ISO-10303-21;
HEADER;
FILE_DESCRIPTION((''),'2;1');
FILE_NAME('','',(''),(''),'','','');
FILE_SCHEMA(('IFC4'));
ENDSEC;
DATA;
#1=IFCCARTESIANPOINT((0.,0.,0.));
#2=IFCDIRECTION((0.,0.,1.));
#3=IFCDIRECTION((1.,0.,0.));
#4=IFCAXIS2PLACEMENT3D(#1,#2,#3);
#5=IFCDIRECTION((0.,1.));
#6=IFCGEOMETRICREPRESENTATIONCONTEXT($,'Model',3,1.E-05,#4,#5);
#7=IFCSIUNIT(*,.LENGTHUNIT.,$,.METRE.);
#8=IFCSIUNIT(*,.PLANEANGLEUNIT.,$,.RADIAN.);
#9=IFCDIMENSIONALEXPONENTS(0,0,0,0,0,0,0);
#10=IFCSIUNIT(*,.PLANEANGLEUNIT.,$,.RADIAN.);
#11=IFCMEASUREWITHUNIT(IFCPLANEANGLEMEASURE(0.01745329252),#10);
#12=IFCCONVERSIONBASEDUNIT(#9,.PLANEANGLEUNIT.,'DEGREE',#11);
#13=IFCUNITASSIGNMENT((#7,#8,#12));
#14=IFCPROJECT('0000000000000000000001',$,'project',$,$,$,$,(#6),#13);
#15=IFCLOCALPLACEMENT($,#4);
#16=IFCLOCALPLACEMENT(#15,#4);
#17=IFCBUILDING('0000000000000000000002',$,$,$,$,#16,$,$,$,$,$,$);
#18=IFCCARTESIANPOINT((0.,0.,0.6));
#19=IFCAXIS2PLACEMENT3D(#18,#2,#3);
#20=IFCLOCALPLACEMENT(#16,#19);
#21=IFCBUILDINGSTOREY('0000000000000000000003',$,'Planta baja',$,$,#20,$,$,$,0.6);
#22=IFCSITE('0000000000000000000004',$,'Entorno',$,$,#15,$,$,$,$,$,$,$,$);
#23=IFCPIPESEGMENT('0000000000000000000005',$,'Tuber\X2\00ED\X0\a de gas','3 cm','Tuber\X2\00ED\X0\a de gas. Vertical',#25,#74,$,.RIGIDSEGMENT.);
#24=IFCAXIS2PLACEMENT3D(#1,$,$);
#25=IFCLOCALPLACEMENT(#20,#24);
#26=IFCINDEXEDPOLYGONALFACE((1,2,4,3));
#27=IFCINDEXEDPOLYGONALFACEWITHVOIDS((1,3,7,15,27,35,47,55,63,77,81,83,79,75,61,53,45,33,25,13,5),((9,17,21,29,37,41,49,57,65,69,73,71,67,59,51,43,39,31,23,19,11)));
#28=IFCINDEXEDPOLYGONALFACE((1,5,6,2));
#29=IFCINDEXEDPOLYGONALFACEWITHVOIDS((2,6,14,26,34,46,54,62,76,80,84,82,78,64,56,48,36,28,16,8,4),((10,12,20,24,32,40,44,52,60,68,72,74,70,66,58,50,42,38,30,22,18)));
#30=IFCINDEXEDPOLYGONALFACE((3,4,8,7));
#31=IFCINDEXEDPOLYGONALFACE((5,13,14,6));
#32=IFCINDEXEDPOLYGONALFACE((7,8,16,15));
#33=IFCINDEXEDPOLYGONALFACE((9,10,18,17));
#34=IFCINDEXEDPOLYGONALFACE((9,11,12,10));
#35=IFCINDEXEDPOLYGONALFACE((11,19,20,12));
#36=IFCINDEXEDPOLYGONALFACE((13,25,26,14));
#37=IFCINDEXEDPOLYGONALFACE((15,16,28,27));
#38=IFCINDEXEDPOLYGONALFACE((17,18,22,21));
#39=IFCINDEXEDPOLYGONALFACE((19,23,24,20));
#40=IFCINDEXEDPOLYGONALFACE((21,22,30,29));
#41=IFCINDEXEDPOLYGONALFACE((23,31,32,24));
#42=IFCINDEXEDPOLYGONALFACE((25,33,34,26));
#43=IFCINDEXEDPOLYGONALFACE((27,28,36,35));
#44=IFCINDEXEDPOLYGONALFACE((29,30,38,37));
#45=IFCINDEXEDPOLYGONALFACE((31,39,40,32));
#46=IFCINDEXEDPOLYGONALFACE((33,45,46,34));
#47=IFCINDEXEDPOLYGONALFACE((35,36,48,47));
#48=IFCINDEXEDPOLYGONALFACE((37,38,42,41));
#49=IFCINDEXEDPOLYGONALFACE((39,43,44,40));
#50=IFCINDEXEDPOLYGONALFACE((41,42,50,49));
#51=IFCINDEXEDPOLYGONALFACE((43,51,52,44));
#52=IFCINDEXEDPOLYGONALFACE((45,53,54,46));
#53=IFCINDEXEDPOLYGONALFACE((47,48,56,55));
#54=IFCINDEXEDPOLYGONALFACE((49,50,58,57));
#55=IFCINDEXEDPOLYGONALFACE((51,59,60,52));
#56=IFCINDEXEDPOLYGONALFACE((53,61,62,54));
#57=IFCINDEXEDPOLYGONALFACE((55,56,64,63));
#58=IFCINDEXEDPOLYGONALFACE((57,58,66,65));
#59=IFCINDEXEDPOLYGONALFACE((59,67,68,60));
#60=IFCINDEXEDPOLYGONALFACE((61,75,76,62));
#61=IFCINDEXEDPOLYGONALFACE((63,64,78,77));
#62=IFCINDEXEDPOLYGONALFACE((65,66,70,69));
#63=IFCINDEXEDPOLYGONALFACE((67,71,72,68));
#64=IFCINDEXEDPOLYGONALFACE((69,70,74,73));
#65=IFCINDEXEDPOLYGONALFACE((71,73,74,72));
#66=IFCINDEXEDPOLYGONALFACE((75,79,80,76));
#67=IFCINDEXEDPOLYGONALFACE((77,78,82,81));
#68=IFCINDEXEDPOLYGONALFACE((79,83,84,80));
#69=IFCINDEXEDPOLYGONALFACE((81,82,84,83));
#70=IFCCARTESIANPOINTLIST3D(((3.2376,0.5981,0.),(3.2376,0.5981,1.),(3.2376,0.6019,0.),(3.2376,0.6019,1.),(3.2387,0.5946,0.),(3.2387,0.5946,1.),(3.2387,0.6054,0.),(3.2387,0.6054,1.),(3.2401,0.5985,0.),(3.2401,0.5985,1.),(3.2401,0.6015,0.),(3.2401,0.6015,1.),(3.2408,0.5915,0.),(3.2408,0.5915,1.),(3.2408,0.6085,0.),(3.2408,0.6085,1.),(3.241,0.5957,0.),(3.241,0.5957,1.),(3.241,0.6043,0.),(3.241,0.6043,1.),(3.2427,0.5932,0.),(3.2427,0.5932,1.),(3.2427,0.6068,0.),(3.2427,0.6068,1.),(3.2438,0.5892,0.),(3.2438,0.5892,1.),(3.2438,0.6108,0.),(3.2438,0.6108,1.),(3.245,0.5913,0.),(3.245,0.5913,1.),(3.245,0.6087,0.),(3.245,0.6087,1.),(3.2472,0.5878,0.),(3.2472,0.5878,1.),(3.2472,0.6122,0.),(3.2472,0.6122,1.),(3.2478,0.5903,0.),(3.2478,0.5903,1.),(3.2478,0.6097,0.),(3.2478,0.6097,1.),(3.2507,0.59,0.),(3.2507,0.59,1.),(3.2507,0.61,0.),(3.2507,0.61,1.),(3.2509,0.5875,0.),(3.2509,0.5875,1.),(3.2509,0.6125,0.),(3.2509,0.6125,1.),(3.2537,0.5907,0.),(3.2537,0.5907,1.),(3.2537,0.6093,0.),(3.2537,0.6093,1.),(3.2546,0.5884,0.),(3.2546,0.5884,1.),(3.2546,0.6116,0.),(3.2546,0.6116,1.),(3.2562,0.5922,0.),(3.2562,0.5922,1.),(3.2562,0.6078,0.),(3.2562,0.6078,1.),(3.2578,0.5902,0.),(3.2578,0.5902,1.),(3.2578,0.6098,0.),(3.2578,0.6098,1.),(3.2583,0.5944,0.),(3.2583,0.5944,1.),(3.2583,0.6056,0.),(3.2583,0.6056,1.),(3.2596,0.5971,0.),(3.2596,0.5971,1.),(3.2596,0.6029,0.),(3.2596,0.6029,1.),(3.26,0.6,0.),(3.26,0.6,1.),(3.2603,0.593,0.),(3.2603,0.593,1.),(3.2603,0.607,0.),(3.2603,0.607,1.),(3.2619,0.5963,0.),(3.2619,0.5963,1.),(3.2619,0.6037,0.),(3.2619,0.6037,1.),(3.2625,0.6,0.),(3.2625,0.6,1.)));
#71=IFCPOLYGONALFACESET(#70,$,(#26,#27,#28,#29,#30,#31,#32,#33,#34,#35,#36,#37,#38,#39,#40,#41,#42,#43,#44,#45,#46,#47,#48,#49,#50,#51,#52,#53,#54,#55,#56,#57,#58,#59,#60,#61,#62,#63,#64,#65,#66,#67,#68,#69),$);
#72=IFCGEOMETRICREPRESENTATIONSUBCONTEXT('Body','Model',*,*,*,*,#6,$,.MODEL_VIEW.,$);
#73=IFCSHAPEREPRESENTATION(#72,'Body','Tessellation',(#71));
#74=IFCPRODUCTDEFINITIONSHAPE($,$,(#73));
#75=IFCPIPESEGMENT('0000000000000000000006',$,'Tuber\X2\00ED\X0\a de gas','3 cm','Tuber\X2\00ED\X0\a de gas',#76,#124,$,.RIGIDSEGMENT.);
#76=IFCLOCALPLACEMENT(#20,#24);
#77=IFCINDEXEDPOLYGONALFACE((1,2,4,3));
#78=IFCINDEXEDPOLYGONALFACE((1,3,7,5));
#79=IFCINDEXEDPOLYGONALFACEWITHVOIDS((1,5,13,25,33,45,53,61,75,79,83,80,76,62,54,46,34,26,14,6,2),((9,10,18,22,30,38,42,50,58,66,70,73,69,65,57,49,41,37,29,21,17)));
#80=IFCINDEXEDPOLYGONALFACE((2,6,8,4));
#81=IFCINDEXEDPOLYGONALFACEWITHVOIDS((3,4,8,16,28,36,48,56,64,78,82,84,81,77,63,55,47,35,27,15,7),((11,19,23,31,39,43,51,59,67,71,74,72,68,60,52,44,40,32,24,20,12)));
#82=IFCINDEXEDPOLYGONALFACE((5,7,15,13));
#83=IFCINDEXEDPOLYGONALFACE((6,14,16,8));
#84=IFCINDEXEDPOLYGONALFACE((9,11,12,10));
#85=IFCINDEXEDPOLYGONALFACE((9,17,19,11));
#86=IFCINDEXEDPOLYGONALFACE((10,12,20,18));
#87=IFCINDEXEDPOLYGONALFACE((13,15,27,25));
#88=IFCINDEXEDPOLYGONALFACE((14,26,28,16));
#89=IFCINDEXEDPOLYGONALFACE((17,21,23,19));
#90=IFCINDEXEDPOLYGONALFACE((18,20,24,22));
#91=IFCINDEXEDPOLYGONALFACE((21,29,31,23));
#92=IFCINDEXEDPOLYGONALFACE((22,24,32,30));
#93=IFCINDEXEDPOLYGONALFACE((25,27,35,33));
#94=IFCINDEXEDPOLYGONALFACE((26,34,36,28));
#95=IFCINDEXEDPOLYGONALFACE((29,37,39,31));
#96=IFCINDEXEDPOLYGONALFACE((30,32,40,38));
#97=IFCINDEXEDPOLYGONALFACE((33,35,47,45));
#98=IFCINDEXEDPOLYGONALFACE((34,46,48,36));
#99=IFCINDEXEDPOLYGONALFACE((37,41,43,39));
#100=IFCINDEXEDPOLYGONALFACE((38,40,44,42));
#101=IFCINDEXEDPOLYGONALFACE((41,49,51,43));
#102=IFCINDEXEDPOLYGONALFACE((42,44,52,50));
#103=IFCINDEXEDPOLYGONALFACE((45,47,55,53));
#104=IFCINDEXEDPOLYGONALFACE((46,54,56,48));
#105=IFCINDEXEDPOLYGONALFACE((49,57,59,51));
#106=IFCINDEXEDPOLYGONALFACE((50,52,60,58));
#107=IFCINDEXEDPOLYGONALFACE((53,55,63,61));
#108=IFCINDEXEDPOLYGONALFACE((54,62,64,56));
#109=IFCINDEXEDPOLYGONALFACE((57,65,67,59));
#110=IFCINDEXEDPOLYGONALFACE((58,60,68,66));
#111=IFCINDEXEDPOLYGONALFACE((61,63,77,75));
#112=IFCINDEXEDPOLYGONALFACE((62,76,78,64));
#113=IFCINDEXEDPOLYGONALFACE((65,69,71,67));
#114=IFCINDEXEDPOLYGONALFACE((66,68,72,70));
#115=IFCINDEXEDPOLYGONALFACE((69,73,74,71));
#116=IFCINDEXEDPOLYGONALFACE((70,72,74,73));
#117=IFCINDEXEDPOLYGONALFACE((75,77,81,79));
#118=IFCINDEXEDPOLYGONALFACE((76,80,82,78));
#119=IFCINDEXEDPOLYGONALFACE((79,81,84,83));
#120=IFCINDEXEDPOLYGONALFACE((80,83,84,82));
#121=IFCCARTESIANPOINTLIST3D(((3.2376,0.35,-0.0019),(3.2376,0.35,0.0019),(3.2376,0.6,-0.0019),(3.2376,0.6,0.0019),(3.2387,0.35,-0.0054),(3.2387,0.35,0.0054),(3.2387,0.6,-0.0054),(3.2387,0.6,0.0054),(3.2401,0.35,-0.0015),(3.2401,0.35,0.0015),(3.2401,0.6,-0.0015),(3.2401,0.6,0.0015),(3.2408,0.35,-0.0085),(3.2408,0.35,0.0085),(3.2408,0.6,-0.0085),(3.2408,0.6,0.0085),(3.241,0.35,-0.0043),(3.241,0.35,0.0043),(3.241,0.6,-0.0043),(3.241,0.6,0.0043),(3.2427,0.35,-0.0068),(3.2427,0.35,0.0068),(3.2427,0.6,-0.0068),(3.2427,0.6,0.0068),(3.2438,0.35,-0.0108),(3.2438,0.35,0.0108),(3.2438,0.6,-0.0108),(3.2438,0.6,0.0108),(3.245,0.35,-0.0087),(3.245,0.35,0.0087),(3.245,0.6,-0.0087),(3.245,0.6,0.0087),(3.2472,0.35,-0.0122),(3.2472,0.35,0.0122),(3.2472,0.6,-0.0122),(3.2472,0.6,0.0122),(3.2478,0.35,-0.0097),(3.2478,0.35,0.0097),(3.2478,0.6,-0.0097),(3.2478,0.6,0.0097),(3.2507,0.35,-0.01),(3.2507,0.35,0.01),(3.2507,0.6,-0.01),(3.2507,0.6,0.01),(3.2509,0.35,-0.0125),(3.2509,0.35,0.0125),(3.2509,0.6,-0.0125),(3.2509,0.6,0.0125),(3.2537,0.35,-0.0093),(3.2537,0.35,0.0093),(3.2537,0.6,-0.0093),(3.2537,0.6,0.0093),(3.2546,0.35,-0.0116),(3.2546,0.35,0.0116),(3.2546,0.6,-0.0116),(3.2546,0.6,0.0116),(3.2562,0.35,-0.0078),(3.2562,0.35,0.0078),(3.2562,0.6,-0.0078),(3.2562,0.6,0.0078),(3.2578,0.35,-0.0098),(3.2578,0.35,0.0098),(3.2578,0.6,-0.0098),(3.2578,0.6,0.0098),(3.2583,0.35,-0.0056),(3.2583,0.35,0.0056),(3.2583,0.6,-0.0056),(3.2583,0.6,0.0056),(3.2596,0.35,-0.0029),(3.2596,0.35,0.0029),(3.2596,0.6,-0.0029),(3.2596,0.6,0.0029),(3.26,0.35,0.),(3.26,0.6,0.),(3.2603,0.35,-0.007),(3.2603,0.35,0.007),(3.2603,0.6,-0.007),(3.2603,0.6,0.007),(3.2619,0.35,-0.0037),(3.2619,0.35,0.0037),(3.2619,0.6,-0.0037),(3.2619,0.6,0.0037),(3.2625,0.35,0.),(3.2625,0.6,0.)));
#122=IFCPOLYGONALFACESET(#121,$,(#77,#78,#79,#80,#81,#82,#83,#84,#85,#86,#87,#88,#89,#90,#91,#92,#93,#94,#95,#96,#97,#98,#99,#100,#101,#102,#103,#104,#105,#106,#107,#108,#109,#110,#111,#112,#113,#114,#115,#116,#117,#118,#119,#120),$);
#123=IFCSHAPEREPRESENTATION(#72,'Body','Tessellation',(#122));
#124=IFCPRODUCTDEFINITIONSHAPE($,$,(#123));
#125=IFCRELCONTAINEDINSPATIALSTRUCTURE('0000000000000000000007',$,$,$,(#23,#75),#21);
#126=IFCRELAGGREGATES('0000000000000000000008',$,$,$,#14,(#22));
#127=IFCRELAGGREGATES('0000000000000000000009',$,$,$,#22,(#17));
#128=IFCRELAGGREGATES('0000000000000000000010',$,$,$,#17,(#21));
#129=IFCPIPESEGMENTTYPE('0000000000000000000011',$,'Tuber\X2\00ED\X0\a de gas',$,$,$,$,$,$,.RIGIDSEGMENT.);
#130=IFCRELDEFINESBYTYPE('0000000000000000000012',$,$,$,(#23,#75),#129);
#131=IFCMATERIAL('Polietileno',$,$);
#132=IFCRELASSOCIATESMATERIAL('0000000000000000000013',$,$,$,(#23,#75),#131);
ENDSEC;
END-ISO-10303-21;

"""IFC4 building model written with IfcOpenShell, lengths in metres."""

from ifc_helpers import new_model, entity, si_unit, converted_unit, direction, frame, origin_with_axes, origin_2d_with_axis, place, context, subcontext, project, spatial, hollow_circle, extrude, material, type_object, element, save


model = new_model("IFC4")

# Units and contexts
model_context = context("Model", 3, precision=1e-05, world=origin_with_axes(), true_north=direction((0.0, 1.0)))
body_context = subcontext(model_context, "Body", "Model", "MODEL_VIEW")
ifc_project = project(units=[si_unit("LENGTHUNIT", "METRE"), si_unit("PLANEANGLEUNIT", "RADIAN"), converted_unit("PLANEANGLEUNIT", "DEGREE", entity("IfcPlaneAngleMeasure", 0.01745329252), si_unit("PLANEANGLEUNIT", "RADIAN"), dimensions=[0, 0, 0, 0, 0, 0, 0])], contexts=[model_context])

# Site, building, storey
site_placement = place(None, origin_with_axes())
site = spatial("IfcSite", under=ifc_project, at=site_placement, Name="Entorno")
building_placement = place(site_placement, origin_with_axes())
building = spatial("IfcBuilding", under=site, at=building_placement)
storey_placement = place(building_placement, frame((0.0, 0.0, 0.6), z_axis=(0.0, 0.0, 1.0), x_axis=(1.0, 0.0, 0.0)))
storey = spatial("IfcBuildingStorey", under=building, at=storey_placement, Name="Planta baja", Elevation=0.6)

# Shared definitions
ifc_material_1 = material(Name="Polietileno")

# Pipe segments
pipe_segment_type_1 = type_object("IfcPipeSegmentType", Name="Tubería de gas", PredefinedType="RIGIDSEGMENT")
pipe_segment_1_placement = place(storey_placement, frame((3.25, 0.6, 0.0), z_axis=(0.0, 0.0, 1.0), x_axis=(1.0, 0.0, 0.0)))
element("IfcPipeSegment", 1, at=pipe_segment_1_placement, inside=storey, type_object=pipe_segment_type_1, material=ifc_material_1, Name="Tubería de gas", Description="3 cm", ObjectType="Tubería de gas. Vertical", PredefinedType="RIGIDSEGMENT", context=body_context, shape_type="SweptSolid", body=[
    extrude(hollow_circle(Radius=0.0125, WallThickness=0.0025, at=origin_2d_with_axis()), origin_with_axes(), (0.0, 0.0, 1.0), 1.0),
])
pipe_segment_2_placement = place(storey_placement, frame((3.25, 0.6, 0.0), z_axis=(0.0, -1.0, 0.0), x_axis=(1.0, 0.0, 0.0)))
element("IfcPipeSegment", 2, at=pipe_segment_2_placement, inside=storey, type_object=pipe_segment_type_1, material=ifc_material_1, Name="Tubería de gas", Description="3 cm", ObjectType="Tubería de gas", PredefinedType="RIGIDSEGMENT", context=body_context, shape_type="SweptSolid", body=[
    extrude(hollow_circle(Radius=0.0125, WallThickness=0.0025, at=origin_2d_with_axis()), origin_with_axes(), (0.0, 0.0, 1.0), 0.25),
])

save(model, "model.ifc")
